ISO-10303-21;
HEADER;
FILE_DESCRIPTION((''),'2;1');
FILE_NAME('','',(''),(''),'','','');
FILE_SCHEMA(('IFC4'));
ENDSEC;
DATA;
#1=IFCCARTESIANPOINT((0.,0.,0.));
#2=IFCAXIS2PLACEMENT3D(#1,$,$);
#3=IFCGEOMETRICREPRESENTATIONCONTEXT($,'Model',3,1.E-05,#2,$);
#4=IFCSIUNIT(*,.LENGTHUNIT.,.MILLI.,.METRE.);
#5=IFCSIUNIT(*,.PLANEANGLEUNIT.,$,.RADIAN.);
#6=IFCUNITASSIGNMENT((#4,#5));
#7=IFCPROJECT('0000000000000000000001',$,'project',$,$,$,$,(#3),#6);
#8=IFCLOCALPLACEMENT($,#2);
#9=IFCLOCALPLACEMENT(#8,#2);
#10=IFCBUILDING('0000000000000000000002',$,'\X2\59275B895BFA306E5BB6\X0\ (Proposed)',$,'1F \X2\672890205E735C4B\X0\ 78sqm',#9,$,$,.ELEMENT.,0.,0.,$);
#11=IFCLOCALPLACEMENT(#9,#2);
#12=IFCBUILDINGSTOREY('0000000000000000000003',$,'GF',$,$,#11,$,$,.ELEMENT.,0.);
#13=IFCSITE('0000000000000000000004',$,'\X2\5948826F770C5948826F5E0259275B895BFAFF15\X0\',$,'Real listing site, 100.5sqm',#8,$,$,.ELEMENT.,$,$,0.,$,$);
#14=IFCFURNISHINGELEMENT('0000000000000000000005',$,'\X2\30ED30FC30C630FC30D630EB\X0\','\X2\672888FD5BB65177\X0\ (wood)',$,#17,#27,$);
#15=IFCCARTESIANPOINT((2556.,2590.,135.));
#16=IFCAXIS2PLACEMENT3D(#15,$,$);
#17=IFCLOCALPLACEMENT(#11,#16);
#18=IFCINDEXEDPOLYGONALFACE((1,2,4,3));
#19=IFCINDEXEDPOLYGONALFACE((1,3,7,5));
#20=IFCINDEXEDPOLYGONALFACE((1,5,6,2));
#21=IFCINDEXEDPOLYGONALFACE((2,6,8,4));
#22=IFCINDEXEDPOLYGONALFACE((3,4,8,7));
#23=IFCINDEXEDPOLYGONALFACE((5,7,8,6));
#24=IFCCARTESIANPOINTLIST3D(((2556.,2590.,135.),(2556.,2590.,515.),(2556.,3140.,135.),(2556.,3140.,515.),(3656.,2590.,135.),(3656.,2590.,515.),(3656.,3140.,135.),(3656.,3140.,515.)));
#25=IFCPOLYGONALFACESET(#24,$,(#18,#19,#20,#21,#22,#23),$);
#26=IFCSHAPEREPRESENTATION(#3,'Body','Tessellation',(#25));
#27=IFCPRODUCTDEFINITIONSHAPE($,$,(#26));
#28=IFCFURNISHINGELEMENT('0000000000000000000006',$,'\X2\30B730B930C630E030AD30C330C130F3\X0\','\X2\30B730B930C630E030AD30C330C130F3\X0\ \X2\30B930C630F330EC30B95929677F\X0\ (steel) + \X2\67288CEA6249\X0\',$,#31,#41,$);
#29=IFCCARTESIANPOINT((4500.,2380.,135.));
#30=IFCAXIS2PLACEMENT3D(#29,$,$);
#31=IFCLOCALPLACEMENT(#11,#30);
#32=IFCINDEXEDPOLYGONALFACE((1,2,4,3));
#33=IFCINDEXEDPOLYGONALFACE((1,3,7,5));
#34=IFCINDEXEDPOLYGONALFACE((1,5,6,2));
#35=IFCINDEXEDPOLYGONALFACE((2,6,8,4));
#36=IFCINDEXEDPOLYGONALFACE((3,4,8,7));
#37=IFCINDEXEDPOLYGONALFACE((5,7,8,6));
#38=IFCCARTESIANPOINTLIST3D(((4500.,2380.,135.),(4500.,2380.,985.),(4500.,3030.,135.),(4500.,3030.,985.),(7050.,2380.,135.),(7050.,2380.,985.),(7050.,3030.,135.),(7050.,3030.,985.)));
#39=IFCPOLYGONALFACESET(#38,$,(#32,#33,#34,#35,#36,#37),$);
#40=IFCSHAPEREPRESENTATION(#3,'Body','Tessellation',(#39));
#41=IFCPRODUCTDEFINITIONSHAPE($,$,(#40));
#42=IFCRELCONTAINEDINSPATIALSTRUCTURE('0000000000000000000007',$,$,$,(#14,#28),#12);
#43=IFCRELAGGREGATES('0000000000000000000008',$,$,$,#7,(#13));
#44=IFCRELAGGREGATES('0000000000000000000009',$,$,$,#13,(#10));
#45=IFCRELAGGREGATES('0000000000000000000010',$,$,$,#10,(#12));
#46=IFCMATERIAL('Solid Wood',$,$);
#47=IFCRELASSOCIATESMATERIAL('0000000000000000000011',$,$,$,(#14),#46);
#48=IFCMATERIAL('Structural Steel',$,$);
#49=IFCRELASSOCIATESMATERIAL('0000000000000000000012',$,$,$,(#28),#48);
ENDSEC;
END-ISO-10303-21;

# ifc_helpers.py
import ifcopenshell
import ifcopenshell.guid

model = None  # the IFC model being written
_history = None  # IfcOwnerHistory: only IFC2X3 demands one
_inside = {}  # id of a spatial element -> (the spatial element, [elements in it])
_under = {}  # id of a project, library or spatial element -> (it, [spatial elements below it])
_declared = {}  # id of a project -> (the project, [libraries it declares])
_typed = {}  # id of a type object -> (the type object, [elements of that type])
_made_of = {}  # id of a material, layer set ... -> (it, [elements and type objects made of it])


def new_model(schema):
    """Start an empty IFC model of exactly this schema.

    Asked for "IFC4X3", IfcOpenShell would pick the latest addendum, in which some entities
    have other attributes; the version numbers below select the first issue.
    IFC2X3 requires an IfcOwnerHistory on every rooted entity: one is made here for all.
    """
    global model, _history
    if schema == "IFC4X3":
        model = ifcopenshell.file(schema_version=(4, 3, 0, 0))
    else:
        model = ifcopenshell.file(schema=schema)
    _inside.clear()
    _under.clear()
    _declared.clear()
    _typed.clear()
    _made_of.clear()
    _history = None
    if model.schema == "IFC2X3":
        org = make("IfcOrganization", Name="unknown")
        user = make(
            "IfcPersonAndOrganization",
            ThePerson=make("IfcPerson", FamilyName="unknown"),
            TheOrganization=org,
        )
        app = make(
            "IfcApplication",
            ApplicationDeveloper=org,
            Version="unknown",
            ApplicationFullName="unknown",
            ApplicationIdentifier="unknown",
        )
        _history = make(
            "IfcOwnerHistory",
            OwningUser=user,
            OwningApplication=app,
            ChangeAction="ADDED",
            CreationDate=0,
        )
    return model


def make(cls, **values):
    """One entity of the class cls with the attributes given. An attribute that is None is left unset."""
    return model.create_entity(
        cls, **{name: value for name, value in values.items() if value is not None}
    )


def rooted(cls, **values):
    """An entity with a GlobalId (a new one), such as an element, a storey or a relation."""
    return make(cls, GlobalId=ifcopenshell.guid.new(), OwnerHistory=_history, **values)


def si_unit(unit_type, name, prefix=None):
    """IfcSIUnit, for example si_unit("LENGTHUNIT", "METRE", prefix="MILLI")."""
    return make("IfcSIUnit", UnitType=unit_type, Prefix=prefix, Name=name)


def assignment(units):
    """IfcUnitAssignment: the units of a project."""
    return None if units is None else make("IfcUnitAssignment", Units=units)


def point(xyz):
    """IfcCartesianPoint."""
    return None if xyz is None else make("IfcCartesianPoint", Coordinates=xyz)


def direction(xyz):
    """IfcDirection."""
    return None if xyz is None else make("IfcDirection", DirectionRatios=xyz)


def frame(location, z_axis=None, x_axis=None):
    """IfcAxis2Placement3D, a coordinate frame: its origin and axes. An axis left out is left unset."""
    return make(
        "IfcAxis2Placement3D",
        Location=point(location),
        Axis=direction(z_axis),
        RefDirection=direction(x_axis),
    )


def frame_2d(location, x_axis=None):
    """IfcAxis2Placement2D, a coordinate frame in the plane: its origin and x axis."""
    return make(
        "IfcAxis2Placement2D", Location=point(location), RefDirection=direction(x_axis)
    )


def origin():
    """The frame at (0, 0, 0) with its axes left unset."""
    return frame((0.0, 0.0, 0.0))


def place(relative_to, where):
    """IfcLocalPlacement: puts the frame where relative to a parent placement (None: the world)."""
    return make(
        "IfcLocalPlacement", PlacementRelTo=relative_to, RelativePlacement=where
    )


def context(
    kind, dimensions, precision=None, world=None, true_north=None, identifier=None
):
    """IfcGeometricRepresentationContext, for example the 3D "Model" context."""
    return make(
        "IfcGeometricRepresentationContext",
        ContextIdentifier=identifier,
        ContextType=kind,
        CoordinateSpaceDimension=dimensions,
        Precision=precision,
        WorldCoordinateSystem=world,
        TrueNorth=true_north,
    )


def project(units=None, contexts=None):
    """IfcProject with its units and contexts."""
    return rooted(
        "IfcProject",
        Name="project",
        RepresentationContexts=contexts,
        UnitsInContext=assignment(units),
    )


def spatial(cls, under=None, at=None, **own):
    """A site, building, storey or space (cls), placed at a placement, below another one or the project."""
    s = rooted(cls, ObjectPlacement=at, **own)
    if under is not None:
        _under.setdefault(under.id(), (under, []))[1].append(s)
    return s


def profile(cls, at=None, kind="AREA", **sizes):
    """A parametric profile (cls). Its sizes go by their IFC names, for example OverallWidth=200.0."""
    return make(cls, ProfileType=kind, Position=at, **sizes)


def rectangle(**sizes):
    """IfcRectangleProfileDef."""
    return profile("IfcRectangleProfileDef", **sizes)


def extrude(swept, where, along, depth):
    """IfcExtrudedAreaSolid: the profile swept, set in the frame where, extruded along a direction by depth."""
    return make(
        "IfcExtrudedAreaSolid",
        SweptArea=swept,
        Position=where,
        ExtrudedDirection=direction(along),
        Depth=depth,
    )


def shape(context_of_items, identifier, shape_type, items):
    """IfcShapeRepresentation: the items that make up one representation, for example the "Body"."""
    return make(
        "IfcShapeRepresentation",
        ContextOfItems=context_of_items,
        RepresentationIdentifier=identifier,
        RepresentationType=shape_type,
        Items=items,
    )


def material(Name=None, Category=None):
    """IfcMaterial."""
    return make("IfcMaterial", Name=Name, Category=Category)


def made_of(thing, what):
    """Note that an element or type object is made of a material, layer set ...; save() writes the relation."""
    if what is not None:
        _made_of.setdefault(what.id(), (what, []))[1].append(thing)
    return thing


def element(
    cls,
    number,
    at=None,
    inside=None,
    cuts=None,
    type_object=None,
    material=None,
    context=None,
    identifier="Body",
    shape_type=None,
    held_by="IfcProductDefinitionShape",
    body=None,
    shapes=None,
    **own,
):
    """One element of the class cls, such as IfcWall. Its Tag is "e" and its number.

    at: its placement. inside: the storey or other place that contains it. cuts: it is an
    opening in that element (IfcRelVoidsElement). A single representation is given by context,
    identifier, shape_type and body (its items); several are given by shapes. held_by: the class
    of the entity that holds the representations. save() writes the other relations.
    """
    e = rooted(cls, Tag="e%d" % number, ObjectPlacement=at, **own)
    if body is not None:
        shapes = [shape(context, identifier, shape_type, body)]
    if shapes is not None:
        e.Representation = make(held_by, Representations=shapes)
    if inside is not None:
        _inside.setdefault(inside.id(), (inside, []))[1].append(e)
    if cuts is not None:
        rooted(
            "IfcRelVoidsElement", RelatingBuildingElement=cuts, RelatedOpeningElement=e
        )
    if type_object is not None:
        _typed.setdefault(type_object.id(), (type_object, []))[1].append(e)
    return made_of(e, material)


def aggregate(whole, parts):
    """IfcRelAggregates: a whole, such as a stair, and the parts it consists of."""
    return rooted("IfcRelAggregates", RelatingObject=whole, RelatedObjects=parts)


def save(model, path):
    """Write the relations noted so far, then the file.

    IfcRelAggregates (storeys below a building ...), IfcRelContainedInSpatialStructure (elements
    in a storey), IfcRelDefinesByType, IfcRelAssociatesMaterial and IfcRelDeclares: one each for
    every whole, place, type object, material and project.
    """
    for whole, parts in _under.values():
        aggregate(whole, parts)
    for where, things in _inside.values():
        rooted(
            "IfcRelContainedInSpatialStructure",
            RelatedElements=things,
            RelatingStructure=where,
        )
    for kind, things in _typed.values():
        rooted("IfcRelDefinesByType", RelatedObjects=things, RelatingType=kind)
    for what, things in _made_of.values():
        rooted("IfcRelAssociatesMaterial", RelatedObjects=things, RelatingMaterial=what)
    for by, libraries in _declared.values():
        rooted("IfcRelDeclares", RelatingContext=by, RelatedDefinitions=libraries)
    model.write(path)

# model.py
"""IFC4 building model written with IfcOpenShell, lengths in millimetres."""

from ifc_helpers import new_model, si_unit, frame, frame_2d, origin, place, context, project, spatial, rectangle, extrude, material, element, save


model = new_model("IFC4")

# Units and contexts
model_context = context("Model", 3, precision=1e-05, world=origin())
ifc_project = project(units=[si_unit("LENGTHUNIT", "METRE", prefix="MILLI"), si_unit("PLANEANGLEUNIT", "RADIAN")], contexts=[model_context])

# Site, building, storey
site_placement = place(None, origin())
site = spatial("IfcSite", under=ifc_project, at=site_placement, Name="奈良県奈良市大安寺５", ObjectType="Real listing site, 100.5sqm", CompositionType="ELEMENT", RefElevation=0.0)
building_placement = place(site_placement, origin())
building = spatial("IfcBuilding", under=site, at=building_placement, Name="大安寺の家 (Proposed)", ObjectType="1F 木造平屋 78sqm", CompositionType="ELEMENT", ElevationOfRefHeight=0.0, ElevationOfTerrain=0.0)
storey_placement = place(building_placement, origin())
storey = spatial("IfcBuildingStorey", under=building, at=storey_placement, Name="GF", CompositionType="ELEMENT", Elevation=0.0)

# Shared definitions
ifc_material_1 = material(Name="Solid Wood")

# Furnishing elements
furnishing_1_placement = place(storey_placement, frame((2556.0, 2590.0, 135.0)))
element("IfcFurnishingElement", 1, at=furnishing_1_placement, inside=storey, material=ifc_material_1, Name="ローテーブル", Description="木製家具 (wood)", context=model_context, shape_type="SweptSolid", body=[
    extrude(rectangle(XDim=1100.0, YDim=550.0, at=frame_2d((550.0, 275.0))), frame((2556.0, 2590.0, 135.0)), (0.0, 0.0, 1.0), 380.0),
])
ifc_material_2 = material(Name="Structural Steel")
furnishing_2_placement = place(storey_placement, frame((4500.0, 2380.0, 135.0)))
element("IfcFurnishingElement", 2, at=furnishing_2_placement, inside=storey, material=ifc_material_2, Name="システムキッチン", Description="システムキッチン ステンレス天板 (steel) + 木質扉", context=model_context, shape_type="SweptSolid", body=[
    extrude(rectangle(XDim=2550.0, YDim=650.0, at=frame_2d((1275.0, 325.0))), frame((4500.0, 2380.0, 135.0)), (0.0, 0.0, 1.0), 850.0),
])

save(model, "model.ifc")
